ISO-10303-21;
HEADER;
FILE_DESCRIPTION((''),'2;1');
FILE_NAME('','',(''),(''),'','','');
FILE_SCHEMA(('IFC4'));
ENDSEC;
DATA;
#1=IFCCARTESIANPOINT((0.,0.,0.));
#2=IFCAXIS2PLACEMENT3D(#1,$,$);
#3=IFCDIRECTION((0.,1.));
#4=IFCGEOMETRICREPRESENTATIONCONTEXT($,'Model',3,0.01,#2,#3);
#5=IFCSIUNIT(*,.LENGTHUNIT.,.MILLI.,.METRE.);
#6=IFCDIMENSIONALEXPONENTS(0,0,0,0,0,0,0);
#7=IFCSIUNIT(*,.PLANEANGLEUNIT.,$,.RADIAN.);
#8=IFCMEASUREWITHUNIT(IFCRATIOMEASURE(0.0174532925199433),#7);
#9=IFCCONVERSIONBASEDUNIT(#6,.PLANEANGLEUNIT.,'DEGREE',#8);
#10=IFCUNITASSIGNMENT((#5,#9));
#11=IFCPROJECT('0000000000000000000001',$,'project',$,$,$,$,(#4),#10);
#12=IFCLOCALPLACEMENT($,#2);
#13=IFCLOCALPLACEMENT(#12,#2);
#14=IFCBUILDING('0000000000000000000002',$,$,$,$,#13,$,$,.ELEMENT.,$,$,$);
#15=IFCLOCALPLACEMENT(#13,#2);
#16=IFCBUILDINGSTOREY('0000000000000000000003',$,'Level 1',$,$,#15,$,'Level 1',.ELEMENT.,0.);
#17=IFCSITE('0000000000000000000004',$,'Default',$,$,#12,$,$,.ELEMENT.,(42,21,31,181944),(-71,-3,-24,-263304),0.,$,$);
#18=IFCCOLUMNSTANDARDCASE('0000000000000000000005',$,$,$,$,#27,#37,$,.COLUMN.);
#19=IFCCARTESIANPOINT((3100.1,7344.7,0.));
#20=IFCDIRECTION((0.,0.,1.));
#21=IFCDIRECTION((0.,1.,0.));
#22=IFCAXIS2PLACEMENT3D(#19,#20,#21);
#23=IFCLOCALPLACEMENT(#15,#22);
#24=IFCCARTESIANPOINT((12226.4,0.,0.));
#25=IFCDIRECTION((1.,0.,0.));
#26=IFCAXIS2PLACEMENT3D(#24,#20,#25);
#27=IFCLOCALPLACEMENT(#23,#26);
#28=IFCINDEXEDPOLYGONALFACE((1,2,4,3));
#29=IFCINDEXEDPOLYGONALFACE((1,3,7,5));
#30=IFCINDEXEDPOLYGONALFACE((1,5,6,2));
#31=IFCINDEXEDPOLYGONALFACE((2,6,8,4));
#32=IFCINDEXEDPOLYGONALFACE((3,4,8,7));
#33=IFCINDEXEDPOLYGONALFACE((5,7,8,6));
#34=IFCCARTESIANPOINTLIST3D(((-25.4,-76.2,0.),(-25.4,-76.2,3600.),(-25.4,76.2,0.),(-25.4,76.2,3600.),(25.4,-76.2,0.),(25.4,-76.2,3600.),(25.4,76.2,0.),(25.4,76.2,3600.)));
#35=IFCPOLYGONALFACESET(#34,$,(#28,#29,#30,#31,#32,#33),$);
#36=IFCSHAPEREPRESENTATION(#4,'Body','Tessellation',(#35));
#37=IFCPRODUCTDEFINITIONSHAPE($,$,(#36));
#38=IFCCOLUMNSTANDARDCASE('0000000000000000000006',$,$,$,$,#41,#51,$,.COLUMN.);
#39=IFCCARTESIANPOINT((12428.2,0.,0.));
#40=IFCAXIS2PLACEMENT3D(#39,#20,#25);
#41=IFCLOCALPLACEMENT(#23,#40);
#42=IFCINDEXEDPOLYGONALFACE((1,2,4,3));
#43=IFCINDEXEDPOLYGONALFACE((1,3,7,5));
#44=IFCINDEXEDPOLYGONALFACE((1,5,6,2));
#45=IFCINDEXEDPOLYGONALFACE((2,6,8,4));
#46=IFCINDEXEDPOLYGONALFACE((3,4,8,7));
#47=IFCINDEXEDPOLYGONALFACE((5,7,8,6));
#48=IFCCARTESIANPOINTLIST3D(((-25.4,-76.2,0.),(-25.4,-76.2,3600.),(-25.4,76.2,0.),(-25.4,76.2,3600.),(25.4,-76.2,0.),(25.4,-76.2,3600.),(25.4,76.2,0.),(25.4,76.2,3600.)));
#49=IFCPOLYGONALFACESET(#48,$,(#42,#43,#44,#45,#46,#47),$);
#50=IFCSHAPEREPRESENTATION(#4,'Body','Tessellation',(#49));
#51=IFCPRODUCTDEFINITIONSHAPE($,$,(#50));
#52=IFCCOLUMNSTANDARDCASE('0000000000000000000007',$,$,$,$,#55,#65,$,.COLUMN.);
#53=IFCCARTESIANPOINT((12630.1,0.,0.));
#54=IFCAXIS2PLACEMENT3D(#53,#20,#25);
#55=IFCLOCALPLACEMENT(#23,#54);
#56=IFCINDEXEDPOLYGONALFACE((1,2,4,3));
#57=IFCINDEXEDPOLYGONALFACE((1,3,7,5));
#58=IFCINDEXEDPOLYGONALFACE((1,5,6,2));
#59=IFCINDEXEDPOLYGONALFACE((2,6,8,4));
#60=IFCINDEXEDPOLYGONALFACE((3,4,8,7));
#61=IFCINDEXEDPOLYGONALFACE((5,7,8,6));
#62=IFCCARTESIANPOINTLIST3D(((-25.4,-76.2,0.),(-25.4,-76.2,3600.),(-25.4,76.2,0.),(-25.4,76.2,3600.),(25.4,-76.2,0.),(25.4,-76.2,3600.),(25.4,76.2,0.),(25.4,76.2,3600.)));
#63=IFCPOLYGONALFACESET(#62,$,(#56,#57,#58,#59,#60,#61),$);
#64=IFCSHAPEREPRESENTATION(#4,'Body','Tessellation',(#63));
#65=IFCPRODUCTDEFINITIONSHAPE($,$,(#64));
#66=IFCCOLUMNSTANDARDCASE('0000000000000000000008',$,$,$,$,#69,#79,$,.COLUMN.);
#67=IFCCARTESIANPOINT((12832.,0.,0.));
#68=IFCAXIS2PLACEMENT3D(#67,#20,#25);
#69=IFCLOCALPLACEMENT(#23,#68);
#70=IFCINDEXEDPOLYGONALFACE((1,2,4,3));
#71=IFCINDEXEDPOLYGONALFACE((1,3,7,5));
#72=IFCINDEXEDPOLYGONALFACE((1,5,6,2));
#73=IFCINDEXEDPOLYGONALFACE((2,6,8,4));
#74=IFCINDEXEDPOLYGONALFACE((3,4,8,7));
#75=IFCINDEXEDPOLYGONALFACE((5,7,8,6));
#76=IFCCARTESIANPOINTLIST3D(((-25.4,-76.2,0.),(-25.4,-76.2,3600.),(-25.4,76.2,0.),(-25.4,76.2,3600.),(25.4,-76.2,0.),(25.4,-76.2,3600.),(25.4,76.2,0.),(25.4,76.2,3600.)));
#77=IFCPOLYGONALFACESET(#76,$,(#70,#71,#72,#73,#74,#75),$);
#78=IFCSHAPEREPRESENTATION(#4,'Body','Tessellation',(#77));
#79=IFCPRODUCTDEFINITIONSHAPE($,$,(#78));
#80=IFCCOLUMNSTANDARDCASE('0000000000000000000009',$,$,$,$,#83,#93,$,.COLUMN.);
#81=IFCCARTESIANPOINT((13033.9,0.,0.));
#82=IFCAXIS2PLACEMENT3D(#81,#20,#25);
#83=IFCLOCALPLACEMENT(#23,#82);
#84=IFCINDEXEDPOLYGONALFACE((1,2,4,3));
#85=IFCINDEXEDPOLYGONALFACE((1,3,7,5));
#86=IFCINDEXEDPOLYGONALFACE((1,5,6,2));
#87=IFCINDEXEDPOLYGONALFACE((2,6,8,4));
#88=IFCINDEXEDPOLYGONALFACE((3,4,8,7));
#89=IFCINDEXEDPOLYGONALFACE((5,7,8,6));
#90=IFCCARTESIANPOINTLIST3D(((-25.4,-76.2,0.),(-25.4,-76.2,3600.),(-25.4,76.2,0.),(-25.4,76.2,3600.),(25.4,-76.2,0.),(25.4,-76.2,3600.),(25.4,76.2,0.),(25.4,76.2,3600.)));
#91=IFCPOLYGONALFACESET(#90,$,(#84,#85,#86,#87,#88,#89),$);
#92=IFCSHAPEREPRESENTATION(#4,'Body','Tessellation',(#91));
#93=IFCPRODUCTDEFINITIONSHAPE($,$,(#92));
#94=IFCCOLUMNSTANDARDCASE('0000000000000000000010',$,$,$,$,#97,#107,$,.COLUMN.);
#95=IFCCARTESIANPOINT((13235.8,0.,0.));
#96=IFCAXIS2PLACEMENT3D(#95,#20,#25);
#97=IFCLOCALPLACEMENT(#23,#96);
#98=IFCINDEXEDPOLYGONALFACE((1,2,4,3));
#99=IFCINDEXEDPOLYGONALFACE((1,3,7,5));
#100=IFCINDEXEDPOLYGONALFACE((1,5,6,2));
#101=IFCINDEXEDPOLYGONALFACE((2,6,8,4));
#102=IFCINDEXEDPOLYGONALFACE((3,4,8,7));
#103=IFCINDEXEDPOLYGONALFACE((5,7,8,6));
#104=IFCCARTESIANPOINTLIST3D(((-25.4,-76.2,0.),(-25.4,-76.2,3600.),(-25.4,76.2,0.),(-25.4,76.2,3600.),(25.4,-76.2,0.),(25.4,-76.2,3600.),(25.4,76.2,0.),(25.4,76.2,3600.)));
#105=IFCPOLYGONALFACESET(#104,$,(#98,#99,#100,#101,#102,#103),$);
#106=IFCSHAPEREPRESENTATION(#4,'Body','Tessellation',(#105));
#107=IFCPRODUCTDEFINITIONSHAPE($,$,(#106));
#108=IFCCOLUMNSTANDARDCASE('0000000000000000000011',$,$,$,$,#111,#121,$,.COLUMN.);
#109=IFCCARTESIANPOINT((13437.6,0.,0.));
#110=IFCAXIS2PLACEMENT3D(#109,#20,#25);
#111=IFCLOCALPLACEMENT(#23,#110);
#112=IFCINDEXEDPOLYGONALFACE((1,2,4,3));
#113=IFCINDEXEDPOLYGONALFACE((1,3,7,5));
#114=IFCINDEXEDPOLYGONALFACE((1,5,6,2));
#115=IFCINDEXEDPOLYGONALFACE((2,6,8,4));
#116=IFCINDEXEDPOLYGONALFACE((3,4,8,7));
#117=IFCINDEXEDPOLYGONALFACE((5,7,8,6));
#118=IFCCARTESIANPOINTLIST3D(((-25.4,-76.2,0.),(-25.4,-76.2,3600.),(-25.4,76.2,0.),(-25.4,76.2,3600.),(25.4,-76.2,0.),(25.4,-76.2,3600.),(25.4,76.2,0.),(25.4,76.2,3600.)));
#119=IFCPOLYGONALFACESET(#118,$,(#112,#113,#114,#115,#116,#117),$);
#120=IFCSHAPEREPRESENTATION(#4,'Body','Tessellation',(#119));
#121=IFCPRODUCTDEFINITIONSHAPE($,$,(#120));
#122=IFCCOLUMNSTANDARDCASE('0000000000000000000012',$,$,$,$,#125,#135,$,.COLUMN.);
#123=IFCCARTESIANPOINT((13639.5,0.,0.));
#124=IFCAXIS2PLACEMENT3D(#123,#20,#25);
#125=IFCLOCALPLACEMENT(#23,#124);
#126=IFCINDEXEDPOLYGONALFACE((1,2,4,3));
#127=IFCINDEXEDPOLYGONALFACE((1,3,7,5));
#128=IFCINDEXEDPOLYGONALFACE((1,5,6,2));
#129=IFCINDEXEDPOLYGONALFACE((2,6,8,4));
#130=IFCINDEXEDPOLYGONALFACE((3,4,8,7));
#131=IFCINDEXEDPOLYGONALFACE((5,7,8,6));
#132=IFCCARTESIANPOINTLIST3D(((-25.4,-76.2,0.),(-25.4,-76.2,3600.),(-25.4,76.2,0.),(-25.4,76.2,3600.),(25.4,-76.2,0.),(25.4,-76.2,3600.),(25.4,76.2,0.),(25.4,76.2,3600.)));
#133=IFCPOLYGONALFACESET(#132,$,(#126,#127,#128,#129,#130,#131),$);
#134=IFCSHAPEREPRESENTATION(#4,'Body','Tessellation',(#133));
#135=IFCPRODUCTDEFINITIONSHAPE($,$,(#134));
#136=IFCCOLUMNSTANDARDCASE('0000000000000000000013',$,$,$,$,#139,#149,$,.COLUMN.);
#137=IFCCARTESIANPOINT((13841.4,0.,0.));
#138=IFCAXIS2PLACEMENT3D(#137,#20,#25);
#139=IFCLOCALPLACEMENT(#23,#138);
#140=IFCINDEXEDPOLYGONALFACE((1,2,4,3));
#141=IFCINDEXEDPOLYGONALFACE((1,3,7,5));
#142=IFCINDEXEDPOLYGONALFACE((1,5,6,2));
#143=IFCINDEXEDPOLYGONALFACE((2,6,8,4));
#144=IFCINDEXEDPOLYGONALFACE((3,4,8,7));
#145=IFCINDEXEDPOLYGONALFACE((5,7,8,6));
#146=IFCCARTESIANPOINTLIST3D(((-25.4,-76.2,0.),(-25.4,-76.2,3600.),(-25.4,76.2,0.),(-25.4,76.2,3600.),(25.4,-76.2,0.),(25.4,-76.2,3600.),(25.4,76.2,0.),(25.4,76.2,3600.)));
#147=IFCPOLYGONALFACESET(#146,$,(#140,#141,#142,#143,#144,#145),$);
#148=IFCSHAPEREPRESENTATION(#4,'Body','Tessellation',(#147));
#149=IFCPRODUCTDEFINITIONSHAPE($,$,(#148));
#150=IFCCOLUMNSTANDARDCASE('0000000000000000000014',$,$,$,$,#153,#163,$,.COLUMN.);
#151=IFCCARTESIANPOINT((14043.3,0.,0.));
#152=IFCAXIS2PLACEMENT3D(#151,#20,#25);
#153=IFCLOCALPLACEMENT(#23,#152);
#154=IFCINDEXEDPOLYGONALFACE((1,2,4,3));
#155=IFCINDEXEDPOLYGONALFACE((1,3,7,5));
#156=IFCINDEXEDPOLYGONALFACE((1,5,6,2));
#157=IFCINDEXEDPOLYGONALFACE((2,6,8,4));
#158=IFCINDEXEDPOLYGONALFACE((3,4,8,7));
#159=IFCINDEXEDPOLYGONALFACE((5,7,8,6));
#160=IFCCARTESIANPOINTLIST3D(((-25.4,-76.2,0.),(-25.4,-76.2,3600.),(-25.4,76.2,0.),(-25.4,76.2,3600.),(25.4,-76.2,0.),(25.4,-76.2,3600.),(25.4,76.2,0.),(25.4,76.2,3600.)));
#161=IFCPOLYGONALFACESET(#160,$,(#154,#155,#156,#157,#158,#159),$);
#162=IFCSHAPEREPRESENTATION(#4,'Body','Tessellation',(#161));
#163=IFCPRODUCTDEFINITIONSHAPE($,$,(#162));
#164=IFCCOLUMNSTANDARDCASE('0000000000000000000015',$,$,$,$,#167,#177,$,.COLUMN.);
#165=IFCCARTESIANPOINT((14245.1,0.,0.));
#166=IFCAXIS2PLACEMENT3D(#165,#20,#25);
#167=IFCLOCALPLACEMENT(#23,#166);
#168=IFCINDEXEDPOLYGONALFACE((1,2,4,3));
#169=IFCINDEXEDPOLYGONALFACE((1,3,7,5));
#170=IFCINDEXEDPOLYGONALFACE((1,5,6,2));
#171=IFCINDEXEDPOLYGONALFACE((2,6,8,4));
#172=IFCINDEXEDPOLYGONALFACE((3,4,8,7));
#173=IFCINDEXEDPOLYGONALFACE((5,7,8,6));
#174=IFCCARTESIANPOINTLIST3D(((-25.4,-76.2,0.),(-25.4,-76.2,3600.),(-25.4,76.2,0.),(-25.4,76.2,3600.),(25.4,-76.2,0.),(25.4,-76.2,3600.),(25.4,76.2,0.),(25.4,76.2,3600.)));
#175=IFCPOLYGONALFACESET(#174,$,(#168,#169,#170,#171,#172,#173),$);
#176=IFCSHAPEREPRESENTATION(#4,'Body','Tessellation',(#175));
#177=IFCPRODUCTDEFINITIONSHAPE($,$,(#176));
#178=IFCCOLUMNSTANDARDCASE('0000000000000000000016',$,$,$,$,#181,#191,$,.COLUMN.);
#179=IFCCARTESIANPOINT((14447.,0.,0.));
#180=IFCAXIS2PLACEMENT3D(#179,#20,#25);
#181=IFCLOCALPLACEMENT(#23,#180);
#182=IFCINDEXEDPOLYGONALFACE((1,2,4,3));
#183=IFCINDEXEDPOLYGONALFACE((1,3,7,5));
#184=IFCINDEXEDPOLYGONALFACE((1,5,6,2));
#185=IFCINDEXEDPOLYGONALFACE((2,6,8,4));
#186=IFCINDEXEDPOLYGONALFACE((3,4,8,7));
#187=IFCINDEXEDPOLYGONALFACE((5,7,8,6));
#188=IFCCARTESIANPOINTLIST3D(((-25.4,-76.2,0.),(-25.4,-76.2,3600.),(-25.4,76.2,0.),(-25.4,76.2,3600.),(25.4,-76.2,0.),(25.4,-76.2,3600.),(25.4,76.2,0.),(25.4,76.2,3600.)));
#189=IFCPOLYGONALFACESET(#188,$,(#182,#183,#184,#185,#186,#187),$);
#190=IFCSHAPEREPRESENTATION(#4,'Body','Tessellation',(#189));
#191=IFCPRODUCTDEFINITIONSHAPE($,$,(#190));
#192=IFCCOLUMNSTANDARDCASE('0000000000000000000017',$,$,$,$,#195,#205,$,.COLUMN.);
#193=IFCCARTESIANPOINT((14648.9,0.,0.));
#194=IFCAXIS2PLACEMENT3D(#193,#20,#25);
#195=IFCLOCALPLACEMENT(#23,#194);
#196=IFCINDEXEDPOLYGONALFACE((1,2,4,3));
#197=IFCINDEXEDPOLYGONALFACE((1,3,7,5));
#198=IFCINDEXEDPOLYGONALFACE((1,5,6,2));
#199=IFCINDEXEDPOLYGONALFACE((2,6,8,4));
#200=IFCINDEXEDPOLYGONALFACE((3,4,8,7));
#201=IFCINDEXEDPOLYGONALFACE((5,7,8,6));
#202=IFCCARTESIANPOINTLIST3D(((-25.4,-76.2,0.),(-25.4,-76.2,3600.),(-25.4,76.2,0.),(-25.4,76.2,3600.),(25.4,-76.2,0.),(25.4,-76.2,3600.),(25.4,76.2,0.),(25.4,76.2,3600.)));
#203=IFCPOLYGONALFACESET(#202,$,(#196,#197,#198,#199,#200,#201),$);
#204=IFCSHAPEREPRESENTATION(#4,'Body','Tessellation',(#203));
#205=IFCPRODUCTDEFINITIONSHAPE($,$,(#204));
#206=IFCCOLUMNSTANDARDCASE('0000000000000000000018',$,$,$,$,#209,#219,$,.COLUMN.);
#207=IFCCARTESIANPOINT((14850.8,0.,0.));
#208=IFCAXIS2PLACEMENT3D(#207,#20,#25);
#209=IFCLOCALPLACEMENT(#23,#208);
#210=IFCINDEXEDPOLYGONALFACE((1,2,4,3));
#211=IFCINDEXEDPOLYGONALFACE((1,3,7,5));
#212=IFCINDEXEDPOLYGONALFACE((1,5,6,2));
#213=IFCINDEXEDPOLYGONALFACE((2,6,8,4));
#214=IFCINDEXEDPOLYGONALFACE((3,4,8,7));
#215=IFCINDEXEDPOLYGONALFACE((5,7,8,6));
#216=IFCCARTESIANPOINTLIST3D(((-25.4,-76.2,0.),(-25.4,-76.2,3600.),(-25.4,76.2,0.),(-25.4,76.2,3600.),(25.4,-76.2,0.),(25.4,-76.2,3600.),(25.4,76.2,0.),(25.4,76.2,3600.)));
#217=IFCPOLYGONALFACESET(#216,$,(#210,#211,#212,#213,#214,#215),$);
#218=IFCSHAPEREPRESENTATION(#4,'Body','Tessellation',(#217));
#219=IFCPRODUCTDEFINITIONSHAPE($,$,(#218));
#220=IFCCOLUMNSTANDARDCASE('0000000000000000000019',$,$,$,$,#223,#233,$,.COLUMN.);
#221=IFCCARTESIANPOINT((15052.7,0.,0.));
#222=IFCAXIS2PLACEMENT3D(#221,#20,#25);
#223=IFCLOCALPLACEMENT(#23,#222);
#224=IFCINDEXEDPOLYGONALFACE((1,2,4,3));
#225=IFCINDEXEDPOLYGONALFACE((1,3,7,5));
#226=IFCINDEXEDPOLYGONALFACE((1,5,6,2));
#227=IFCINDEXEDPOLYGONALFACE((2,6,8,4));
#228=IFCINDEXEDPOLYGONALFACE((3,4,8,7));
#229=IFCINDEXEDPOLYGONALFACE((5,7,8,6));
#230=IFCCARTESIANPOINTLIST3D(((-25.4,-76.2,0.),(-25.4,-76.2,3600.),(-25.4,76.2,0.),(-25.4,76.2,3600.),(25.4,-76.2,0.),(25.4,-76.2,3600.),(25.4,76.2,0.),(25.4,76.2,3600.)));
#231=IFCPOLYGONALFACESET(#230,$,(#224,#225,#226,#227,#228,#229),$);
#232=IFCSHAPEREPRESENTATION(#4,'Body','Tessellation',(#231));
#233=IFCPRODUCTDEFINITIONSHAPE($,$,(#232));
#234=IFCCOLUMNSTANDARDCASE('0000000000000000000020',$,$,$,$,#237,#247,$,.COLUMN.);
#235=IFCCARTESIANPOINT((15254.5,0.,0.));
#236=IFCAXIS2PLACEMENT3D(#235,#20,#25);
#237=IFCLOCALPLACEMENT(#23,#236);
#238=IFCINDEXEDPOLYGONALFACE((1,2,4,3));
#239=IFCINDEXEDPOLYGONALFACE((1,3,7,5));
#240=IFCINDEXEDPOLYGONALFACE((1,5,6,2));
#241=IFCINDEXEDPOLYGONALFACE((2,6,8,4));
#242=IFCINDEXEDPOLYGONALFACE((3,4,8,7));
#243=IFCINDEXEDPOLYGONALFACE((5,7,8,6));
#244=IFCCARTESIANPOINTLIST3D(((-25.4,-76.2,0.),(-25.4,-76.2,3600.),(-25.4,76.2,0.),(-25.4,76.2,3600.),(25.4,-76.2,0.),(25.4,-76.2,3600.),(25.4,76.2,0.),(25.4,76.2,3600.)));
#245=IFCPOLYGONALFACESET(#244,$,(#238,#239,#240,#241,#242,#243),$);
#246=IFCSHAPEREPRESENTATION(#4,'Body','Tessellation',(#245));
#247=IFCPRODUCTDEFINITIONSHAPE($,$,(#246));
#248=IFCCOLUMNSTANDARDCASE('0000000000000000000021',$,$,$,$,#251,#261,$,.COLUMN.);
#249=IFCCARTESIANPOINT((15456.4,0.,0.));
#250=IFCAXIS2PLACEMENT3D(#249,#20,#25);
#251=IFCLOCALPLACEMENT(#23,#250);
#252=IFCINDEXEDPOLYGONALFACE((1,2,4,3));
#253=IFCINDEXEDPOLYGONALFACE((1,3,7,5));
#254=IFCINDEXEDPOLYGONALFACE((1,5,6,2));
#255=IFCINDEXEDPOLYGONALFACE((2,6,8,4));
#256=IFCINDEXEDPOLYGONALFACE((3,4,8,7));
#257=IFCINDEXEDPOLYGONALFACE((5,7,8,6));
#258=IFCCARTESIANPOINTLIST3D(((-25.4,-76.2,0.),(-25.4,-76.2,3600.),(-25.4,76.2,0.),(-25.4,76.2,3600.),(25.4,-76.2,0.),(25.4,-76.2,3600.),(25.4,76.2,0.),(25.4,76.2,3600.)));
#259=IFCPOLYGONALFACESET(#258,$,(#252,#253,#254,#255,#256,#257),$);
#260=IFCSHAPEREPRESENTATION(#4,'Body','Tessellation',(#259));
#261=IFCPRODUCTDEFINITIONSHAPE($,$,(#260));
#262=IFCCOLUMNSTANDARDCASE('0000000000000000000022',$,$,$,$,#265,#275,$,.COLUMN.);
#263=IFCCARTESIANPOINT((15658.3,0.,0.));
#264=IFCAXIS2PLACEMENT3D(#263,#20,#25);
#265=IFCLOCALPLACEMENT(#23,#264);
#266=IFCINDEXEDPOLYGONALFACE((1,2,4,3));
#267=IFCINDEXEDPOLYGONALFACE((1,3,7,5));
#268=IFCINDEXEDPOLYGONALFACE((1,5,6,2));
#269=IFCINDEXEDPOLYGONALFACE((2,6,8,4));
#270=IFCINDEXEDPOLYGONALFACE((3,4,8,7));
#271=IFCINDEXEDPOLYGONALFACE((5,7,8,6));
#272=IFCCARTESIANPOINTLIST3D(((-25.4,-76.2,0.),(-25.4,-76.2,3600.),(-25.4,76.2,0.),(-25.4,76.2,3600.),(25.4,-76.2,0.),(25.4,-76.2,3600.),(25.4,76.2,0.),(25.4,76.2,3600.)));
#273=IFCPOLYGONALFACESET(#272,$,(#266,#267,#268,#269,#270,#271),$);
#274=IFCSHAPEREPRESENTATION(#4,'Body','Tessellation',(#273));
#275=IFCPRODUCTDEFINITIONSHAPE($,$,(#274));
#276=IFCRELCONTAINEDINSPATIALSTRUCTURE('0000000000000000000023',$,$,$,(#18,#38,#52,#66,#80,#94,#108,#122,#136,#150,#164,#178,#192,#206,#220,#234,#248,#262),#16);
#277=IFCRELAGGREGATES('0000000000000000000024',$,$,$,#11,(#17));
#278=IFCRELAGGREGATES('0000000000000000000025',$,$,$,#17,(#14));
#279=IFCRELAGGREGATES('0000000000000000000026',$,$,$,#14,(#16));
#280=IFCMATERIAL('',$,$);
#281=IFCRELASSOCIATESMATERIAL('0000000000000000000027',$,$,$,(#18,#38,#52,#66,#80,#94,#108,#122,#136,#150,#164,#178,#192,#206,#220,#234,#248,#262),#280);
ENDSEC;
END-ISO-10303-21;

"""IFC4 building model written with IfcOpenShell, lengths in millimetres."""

from ifc_helpers import new_model, entity, si_unit, converted_unit, direction, frame, origin, place, context, project, spatial, rectangle, extrude, material, element, save


model = new_model("IFC4")

# Units and contexts
model_context = context("Model", 3, precision=0.01, world=origin(), true_north=direction((0.0, 1.0)))
ifc_project = project(units=[si_unit("LENGTHUNIT", "METRE", prefix="MILLI"), converted_unit("PLANEANGLEUNIT", "DEGREE", entity("IfcRatioMeasure", 0.0174532925199433), si_unit("PLANEANGLEUNIT", "RADIAN"), dimensions=[0, 0, 0, 0, 0, 0, 0])], contexts=[model_context])

# Site, building, storey
site_placement = place(None, origin())
site = spatial("IfcSite", under=ifc_project, at=site_placement, Name="Default", CompositionType="ELEMENT", RefLatitude=(42, 21, 31, 181944), RefLongitude=(-71, -3, -24, -263304), RefElevation=0.0)
building_placement = place(site_placement, origin())
building = spatial("IfcBuilding", under=site, at=building_placement, CompositionType="ELEMENT")
storey_placement = place(building_placement, origin())
storey = spatial("IfcBuildingStorey", under=building, at=storey_placement, Name="Level 1", LongName="Level 1", CompositionType="ELEMENT", Elevation=0.0)

# Columns
ifc_material = material(Name="")
placement = place(storey_placement, frame((3100.1, 7344.7, 0.0), z_axis=(0.0, 0.0, 1.0), x_axis=(0.0, 1.0, 0.0)))
for number, where, z_axis, x_axis in (
    (1, (12226.4, 0.0, 0.0), (0.0, 0.0, 1.0), (1.0, 0.0, 0.0)),
    (2, (12428.2, 0.0, 0.0), (0.0, 0.0, 1.0), (1.0, 0.0, 0.0)),
    (3, (12630.1, 0.0, 0.0), (0.0, 0.0, 1.0), (1.0, 0.0, 0.0)),
    (4, (12832.0, 0.0, 0.0), (0.0, 0.0, 1.0), (1.0, 0.0, 0.0)),
    (5, (13033.9, 0.0, 0.0), (0.0, 0.0, 1.0), (1.0, 0.0, 0.0)),
    (6, (13235.8, 0.0, 0.0), (0.0, 0.0, 1.0), (1.0, 0.0, 0.0)),
    (7, (13437.6, 0.0, 0.0), (0.0, 0.0, 1.0), (1.0, 0.0, 0.0)),
    (8, (13639.5, 0.0, 0.0), (0.0, 0.0, 1.0), (1.0, 0.0, 0.0)),
    (9, (13841.4, 0.0, 0.0), (0.0, 0.0, 1.0), (1.0, 0.0, 0.0)),
    (10, (14043.3, 0.0, 0.0), (0.0, 0.0, 1.0), (1.0, 0.0, 0.0)),
    (11, (14245.1, 0.0, 0.0), (0.0, 0.0, 1.0), (1.0, 0.0, 0.0)),
    (12, (14447.0, 0.0, 0.0), (0.0, 0.0, 1.0), (1.0, 0.0, 0.0)),
    (13, (14648.9, 0.0, 0.0), (0.0, 0.0, 1.0), (1.0, 0.0, 0.0)),
    (14, (14850.8, 0.0, 0.0), (0.0, 0.0, 1.0), (1.0, 0.0, 0.0)),
    (15, (15052.7, 0.0, 0.0), (0.0, 0.0, 1.0), (1.0, 0.0, 0.0)),
    (16, (15254.5, 0.0, 0.0), (0.0, 0.0, 1.0), (1.0, 0.0, 0.0)),
    (17, (15456.4, 0.0, 0.0), (0.0, 0.0, 1.0), (1.0, 0.0, 0.0)),
    (18, (15658.3, 0.0, 0.0), (0.0, 0.0, 1.0), (1.0, 0.0, 0.0)),
):
    element("IfcColumnStandardCase", number, at=place(placement, frame(where, z_axis=z_axis, x_axis=x_axis)), inside=storey, material=ifc_material, PredefinedType="COLUMN", context=model_context, shape_type="SweptSolid", body=[
        extrude(rectangle(XDim=50.8, YDim=152.4), origin(), (0.0, 0.0, 1.0), 3600.0),
    ])

save(model, "model.ifc")
